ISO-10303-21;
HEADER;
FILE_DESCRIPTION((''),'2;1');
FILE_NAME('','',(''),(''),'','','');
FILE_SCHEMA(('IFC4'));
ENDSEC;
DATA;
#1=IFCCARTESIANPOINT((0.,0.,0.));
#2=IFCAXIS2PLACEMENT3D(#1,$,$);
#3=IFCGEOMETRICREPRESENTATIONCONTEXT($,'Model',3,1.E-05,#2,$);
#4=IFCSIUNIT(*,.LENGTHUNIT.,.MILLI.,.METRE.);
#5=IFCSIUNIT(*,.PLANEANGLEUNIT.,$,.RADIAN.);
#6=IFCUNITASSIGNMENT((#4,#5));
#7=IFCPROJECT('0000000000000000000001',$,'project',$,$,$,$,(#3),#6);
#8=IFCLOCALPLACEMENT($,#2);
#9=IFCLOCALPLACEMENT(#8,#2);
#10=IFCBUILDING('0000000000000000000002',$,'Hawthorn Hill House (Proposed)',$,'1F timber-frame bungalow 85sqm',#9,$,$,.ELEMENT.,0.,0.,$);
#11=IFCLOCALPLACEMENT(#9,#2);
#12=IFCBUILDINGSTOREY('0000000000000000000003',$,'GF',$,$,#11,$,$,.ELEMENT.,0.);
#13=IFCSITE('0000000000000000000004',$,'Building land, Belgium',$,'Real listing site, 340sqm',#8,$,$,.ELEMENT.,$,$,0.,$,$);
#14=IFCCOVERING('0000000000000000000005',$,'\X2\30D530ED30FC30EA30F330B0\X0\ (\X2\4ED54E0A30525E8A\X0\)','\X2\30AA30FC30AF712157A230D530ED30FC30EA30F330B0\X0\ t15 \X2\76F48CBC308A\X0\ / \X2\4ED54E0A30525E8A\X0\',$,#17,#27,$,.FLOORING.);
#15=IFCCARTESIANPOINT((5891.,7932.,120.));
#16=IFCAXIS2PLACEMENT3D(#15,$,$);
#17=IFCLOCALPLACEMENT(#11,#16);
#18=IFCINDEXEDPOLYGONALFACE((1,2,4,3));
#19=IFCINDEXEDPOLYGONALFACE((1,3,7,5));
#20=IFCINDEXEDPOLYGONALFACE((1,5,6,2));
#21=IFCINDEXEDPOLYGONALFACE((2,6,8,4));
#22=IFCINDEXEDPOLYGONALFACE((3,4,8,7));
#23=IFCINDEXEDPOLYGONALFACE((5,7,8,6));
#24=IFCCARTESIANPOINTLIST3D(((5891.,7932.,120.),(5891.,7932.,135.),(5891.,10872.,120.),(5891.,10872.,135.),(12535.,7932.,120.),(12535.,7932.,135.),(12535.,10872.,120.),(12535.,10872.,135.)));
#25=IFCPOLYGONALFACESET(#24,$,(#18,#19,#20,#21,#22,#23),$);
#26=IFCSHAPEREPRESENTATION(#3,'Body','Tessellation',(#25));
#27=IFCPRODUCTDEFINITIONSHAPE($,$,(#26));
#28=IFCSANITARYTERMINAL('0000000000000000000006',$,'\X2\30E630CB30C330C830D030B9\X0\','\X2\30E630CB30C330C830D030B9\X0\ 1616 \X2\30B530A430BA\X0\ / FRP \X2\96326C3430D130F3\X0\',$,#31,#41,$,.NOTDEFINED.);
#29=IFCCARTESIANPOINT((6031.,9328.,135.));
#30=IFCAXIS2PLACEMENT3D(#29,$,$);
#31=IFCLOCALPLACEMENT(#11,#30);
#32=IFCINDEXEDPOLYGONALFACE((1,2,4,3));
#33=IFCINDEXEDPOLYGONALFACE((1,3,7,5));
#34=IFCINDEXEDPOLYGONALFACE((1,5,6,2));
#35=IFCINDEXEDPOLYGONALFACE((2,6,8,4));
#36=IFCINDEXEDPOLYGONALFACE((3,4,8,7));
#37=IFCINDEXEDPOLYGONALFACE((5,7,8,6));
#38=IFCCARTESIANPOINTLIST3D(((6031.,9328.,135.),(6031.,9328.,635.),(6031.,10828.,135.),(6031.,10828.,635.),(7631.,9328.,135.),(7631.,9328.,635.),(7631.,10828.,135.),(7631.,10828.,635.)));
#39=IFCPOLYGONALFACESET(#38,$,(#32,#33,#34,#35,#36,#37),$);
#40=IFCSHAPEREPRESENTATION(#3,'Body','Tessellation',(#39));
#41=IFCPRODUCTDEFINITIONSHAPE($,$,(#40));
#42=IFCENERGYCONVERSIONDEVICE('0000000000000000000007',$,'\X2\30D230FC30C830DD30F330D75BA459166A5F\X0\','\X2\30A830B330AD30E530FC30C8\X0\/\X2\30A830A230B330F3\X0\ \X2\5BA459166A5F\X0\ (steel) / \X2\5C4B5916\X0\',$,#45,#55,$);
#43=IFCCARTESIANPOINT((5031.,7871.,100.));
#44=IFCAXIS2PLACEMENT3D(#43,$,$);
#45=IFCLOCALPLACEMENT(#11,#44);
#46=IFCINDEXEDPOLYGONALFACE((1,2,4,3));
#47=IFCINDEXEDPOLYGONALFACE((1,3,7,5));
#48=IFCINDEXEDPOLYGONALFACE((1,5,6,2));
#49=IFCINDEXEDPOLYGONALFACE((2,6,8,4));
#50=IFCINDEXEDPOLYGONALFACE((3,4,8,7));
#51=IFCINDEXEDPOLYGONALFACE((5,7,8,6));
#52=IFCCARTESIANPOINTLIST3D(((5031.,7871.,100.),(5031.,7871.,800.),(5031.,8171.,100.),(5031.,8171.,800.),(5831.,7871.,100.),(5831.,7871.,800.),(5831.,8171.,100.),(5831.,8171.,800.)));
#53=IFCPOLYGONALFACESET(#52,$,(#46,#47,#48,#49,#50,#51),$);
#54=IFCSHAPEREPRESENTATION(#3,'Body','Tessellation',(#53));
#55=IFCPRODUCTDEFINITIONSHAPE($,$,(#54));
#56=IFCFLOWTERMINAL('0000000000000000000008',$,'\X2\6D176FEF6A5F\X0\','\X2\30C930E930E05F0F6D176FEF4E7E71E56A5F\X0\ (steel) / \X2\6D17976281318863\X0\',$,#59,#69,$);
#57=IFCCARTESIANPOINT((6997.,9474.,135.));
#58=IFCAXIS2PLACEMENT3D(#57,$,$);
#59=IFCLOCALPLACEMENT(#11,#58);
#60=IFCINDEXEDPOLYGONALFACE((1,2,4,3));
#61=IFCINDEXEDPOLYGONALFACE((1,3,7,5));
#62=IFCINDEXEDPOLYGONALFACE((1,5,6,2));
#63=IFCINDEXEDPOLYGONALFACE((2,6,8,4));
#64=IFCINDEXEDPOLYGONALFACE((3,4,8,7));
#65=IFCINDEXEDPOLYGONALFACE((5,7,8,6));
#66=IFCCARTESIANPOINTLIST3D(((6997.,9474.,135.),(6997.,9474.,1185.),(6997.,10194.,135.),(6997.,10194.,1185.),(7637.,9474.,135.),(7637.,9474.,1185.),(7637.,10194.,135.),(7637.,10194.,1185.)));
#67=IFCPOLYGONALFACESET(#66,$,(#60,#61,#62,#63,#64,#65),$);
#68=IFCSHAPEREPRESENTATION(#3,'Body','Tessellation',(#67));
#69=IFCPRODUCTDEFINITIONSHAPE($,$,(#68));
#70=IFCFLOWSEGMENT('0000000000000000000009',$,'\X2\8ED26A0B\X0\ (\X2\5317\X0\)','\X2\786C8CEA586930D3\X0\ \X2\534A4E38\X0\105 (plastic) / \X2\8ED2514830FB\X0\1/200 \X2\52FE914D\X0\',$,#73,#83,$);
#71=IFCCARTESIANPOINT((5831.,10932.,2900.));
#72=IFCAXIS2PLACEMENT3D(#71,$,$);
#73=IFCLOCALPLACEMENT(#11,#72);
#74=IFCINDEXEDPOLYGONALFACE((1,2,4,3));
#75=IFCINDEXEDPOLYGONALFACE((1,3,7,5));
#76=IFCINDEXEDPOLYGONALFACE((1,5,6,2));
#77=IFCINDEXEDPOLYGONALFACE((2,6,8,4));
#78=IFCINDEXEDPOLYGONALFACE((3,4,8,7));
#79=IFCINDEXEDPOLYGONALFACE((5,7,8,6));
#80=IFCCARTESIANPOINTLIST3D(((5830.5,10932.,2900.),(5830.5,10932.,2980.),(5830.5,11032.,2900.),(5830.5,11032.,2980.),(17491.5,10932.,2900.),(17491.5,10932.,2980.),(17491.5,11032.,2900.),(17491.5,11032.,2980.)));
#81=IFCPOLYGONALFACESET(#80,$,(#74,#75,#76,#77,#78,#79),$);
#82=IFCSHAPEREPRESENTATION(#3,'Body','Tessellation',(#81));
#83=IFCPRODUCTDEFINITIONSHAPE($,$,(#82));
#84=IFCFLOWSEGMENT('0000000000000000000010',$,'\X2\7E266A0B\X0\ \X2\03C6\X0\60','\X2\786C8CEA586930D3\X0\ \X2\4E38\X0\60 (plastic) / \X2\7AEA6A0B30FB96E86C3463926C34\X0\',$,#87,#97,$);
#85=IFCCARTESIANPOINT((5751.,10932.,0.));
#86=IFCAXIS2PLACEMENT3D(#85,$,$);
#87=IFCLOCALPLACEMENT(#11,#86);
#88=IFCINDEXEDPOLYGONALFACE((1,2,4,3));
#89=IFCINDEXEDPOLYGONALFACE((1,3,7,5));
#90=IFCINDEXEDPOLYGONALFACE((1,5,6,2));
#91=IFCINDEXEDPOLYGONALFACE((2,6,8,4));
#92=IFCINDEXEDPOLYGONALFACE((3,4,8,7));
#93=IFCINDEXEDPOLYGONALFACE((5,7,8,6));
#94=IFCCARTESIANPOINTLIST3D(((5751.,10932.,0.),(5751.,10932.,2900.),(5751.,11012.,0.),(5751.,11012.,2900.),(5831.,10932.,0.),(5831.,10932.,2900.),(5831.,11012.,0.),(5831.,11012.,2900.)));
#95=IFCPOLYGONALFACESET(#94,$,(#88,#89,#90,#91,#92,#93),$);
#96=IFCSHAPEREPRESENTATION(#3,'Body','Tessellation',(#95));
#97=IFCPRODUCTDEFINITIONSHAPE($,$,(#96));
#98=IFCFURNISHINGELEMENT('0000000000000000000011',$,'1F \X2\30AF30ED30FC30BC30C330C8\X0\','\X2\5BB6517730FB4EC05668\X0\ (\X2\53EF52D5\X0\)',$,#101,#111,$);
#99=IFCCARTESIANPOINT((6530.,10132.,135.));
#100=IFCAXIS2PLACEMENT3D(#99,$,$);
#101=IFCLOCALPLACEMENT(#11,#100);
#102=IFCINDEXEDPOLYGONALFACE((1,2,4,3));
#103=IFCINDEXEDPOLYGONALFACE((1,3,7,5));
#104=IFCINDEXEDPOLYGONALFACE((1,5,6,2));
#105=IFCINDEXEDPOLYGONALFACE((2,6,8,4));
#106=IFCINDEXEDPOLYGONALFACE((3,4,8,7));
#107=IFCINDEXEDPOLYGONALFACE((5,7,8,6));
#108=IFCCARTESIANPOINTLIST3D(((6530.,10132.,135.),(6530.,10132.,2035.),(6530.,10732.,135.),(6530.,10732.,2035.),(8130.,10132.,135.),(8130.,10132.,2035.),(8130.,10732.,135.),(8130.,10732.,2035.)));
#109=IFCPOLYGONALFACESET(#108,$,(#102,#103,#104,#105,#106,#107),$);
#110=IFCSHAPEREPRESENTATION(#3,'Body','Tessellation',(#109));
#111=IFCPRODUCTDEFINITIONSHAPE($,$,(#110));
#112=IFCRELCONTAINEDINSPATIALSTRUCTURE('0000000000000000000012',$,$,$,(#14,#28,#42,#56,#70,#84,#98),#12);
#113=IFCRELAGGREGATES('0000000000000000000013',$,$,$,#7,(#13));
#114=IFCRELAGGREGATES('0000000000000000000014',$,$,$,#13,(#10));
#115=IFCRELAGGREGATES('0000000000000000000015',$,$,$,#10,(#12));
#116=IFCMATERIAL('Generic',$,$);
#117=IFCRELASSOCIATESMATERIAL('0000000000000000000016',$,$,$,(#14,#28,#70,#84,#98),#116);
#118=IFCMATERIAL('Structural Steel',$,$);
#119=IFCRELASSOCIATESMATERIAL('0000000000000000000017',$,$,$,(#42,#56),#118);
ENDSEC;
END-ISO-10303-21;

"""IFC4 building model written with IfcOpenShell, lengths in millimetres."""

from ifc_helpers import new_model, si_unit, frame, frame_2d, origin, place, context, project, spatial, rectangle, extrude, material, element, save


model = new_model("IFC4")

# Units and contexts
model_context = context("Model", 3, precision=1e-05, world=origin())
ifc_project = project(units=[si_unit("LENGTHUNIT", "METRE", prefix="MILLI"), si_unit("PLANEANGLEUNIT", "RADIAN")], contexts=[model_context])

# Site, building, storey
site_placement = place(None, origin())
site = spatial("IfcSite", under=ifc_project, at=site_placement, Name="Building land, Belgium", ObjectType="Real listing site, 340sqm", CompositionType="ELEMENT", RefElevation=0.0)
building_placement = place(site_placement, origin())
building = spatial("IfcBuilding", under=site, at=building_placement, Name="Hawthorn Hill House (Proposed)", ObjectType="1F timber-frame bungalow 85sqm", CompositionType="ELEMENT", ElevationOfRefHeight=0.0, ElevationOfTerrain=0.0)
storey_placement = place(building_placement, origin())
storey = spatial("IfcBuildingStorey", under=building, at=storey_placement, Name="GF", CompositionType="ELEMENT", Elevation=0.0)

# Shared definitions
ifc_material_1 = material(Name="Structural Steel")

# Covering
ifc_material_2 = material(Name="Generic")
covering_placement = place(storey_placement, frame((5891.0, 7932.0, 120.0)))
element("IfcCovering", 1, at=covering_placement, inside=storey, material=ifc_material_2, Name="フローリング (仕上げ床)", Description="オーク無垢フローリング t15 直貼り / 仕上げ床", PredefinedType="FLOORING", context=model_context, shape_type="SweptSolid", body=[
    extrude(rectangle(XDim=6644.0, YDim=2940.0, at=frame_2d((3322.0, 1470.0))), frame((5891.0, 7932.0, 120.0)), (0.0, 0.0, 1.0), 15.0),
])

# Sanitary terminal
sanitary_terminal_placement = place(storey_placement, frame((6031.0, 9328.0, 135.0)))
element("IfcSanitaryTerminal", 2, at=sanitary_terminal_placement, inside=storey, material=ifc_material_2, Name="ユニットバス", Description="ユニットバス 1616 サイズ / FRP 防水パン", PredefinedType="NOTDEFINED", context=model_context, shape_type="SweptSolid", body=[
    extrude(rectangle(XDim=1600.0, YDim=1500.0, at=frame_2d((800.0, 750.0))), frame((6031.0, 9328.0, 135.0)), (0.0, 0.0, 1.0), 500.0),
])

# Energy conversion device
energy_conversion_device_placement = place(storey_placement, frame((5031.0, 7871.0, 100.0)))
element("IfcEnergyConversionDevice", 3, at=energy_conversion_device_placement, inside=storey, material=ifc_material_1, Name="ヒートポンプ室外機", Description="エコキュート/エアコン 室外機 (steel) / 屋外", context=model_context, shape_type="SweptSolid", body=[
    extrude(rectangle(XDim=800.0, YDim=300.0, at=frame_2d((400.0, 150.0))), frame((5031.0, 7871.0, 100.0)), (0.0, 0.0, 1.0), 700.0),
])

# Flow terminal
flow_terminal_placement = place(storey_placement, frame((6997.0, 9474.0, 135.0)))
element("IfcFlowTerminal", 4, at=flow_terminal_placement, inside=storey, material=ifc_material_1, Name="洗濯機", Description="ドラム式洗濯乾燥機 (steel) / 洗面脱衣", context=model_context, shape_type="SweptSolid", body=[
    extrude(rectangle(XDim=640.0, YDim=720.0, at=frame_2d((320.0, 360.0))), frame((6997.0, 9474.0, 135.0)), (0.0, 0.0, 1.0), 1050.0),
])

# Flow segments
flow_segment_1_placement = place(storey_placement, frame((5831.0, 10932.0, 2900.0)))
element("IfcFlowSegment", 5, at=flow_segment_1_placement, inside=storey, material=ifc_material_2, Name="軒樋 (北)", Description="硬質塩ビ 半丸105 (plastic) / 軒先・1/200 勾配", context=model_context, shape_type="SweptSolid", body=[
    extrude(rectangle(XDim=11661.0, YDim=100.0, at=frame_2d((5830.0, 50.0))), frame((5831.0, 10932.0, 2900.0)), (0.0, 0.0, 1.0), 80.0),
])
flow_segment_2_placement = place(storey_placement, frame((5751.0, 10932.0, 0.0)))
element("IfcFlowSegment", 6, at=flow_segment_2_placement, inside=storey, material=ifc_material_2, Name="縦樋 φ60", Description="硬質塩ビ 丸60 (plastic) / 竪樋・雨水排水", context=model_context, shape_type="SweptSolid", body=[
    extrude(rectangle(XDim=80.0, YDim=80.0, at=frame_2d((40.0, 40.0))), frame((5751.0, 10932.0, 0.0)), (0.0, 0.0, 1.0), 2900.0),
])

# Furnishing element
furnishing_placement = place(storey_placement, frame((6530.0, 10132.0, 135.0)))
element("IfcFurnishingElement", 7, at=furnishing_placement, inside=storey, material=ifc_material_2, Name="1F クローゼット", Description="家具・什器 (可動)", context=model_context, shape_type="SweptSolid", body=[
    extrude(rectangle(XDim=1600.0, YDim=600.0, at=frame_2d((800.0, 300.0))), frame((6530.0, 10132.0, 135.0)), (0.0, 0.0, 1.0), 1900.0),
])

save(model, "model.ifc")
